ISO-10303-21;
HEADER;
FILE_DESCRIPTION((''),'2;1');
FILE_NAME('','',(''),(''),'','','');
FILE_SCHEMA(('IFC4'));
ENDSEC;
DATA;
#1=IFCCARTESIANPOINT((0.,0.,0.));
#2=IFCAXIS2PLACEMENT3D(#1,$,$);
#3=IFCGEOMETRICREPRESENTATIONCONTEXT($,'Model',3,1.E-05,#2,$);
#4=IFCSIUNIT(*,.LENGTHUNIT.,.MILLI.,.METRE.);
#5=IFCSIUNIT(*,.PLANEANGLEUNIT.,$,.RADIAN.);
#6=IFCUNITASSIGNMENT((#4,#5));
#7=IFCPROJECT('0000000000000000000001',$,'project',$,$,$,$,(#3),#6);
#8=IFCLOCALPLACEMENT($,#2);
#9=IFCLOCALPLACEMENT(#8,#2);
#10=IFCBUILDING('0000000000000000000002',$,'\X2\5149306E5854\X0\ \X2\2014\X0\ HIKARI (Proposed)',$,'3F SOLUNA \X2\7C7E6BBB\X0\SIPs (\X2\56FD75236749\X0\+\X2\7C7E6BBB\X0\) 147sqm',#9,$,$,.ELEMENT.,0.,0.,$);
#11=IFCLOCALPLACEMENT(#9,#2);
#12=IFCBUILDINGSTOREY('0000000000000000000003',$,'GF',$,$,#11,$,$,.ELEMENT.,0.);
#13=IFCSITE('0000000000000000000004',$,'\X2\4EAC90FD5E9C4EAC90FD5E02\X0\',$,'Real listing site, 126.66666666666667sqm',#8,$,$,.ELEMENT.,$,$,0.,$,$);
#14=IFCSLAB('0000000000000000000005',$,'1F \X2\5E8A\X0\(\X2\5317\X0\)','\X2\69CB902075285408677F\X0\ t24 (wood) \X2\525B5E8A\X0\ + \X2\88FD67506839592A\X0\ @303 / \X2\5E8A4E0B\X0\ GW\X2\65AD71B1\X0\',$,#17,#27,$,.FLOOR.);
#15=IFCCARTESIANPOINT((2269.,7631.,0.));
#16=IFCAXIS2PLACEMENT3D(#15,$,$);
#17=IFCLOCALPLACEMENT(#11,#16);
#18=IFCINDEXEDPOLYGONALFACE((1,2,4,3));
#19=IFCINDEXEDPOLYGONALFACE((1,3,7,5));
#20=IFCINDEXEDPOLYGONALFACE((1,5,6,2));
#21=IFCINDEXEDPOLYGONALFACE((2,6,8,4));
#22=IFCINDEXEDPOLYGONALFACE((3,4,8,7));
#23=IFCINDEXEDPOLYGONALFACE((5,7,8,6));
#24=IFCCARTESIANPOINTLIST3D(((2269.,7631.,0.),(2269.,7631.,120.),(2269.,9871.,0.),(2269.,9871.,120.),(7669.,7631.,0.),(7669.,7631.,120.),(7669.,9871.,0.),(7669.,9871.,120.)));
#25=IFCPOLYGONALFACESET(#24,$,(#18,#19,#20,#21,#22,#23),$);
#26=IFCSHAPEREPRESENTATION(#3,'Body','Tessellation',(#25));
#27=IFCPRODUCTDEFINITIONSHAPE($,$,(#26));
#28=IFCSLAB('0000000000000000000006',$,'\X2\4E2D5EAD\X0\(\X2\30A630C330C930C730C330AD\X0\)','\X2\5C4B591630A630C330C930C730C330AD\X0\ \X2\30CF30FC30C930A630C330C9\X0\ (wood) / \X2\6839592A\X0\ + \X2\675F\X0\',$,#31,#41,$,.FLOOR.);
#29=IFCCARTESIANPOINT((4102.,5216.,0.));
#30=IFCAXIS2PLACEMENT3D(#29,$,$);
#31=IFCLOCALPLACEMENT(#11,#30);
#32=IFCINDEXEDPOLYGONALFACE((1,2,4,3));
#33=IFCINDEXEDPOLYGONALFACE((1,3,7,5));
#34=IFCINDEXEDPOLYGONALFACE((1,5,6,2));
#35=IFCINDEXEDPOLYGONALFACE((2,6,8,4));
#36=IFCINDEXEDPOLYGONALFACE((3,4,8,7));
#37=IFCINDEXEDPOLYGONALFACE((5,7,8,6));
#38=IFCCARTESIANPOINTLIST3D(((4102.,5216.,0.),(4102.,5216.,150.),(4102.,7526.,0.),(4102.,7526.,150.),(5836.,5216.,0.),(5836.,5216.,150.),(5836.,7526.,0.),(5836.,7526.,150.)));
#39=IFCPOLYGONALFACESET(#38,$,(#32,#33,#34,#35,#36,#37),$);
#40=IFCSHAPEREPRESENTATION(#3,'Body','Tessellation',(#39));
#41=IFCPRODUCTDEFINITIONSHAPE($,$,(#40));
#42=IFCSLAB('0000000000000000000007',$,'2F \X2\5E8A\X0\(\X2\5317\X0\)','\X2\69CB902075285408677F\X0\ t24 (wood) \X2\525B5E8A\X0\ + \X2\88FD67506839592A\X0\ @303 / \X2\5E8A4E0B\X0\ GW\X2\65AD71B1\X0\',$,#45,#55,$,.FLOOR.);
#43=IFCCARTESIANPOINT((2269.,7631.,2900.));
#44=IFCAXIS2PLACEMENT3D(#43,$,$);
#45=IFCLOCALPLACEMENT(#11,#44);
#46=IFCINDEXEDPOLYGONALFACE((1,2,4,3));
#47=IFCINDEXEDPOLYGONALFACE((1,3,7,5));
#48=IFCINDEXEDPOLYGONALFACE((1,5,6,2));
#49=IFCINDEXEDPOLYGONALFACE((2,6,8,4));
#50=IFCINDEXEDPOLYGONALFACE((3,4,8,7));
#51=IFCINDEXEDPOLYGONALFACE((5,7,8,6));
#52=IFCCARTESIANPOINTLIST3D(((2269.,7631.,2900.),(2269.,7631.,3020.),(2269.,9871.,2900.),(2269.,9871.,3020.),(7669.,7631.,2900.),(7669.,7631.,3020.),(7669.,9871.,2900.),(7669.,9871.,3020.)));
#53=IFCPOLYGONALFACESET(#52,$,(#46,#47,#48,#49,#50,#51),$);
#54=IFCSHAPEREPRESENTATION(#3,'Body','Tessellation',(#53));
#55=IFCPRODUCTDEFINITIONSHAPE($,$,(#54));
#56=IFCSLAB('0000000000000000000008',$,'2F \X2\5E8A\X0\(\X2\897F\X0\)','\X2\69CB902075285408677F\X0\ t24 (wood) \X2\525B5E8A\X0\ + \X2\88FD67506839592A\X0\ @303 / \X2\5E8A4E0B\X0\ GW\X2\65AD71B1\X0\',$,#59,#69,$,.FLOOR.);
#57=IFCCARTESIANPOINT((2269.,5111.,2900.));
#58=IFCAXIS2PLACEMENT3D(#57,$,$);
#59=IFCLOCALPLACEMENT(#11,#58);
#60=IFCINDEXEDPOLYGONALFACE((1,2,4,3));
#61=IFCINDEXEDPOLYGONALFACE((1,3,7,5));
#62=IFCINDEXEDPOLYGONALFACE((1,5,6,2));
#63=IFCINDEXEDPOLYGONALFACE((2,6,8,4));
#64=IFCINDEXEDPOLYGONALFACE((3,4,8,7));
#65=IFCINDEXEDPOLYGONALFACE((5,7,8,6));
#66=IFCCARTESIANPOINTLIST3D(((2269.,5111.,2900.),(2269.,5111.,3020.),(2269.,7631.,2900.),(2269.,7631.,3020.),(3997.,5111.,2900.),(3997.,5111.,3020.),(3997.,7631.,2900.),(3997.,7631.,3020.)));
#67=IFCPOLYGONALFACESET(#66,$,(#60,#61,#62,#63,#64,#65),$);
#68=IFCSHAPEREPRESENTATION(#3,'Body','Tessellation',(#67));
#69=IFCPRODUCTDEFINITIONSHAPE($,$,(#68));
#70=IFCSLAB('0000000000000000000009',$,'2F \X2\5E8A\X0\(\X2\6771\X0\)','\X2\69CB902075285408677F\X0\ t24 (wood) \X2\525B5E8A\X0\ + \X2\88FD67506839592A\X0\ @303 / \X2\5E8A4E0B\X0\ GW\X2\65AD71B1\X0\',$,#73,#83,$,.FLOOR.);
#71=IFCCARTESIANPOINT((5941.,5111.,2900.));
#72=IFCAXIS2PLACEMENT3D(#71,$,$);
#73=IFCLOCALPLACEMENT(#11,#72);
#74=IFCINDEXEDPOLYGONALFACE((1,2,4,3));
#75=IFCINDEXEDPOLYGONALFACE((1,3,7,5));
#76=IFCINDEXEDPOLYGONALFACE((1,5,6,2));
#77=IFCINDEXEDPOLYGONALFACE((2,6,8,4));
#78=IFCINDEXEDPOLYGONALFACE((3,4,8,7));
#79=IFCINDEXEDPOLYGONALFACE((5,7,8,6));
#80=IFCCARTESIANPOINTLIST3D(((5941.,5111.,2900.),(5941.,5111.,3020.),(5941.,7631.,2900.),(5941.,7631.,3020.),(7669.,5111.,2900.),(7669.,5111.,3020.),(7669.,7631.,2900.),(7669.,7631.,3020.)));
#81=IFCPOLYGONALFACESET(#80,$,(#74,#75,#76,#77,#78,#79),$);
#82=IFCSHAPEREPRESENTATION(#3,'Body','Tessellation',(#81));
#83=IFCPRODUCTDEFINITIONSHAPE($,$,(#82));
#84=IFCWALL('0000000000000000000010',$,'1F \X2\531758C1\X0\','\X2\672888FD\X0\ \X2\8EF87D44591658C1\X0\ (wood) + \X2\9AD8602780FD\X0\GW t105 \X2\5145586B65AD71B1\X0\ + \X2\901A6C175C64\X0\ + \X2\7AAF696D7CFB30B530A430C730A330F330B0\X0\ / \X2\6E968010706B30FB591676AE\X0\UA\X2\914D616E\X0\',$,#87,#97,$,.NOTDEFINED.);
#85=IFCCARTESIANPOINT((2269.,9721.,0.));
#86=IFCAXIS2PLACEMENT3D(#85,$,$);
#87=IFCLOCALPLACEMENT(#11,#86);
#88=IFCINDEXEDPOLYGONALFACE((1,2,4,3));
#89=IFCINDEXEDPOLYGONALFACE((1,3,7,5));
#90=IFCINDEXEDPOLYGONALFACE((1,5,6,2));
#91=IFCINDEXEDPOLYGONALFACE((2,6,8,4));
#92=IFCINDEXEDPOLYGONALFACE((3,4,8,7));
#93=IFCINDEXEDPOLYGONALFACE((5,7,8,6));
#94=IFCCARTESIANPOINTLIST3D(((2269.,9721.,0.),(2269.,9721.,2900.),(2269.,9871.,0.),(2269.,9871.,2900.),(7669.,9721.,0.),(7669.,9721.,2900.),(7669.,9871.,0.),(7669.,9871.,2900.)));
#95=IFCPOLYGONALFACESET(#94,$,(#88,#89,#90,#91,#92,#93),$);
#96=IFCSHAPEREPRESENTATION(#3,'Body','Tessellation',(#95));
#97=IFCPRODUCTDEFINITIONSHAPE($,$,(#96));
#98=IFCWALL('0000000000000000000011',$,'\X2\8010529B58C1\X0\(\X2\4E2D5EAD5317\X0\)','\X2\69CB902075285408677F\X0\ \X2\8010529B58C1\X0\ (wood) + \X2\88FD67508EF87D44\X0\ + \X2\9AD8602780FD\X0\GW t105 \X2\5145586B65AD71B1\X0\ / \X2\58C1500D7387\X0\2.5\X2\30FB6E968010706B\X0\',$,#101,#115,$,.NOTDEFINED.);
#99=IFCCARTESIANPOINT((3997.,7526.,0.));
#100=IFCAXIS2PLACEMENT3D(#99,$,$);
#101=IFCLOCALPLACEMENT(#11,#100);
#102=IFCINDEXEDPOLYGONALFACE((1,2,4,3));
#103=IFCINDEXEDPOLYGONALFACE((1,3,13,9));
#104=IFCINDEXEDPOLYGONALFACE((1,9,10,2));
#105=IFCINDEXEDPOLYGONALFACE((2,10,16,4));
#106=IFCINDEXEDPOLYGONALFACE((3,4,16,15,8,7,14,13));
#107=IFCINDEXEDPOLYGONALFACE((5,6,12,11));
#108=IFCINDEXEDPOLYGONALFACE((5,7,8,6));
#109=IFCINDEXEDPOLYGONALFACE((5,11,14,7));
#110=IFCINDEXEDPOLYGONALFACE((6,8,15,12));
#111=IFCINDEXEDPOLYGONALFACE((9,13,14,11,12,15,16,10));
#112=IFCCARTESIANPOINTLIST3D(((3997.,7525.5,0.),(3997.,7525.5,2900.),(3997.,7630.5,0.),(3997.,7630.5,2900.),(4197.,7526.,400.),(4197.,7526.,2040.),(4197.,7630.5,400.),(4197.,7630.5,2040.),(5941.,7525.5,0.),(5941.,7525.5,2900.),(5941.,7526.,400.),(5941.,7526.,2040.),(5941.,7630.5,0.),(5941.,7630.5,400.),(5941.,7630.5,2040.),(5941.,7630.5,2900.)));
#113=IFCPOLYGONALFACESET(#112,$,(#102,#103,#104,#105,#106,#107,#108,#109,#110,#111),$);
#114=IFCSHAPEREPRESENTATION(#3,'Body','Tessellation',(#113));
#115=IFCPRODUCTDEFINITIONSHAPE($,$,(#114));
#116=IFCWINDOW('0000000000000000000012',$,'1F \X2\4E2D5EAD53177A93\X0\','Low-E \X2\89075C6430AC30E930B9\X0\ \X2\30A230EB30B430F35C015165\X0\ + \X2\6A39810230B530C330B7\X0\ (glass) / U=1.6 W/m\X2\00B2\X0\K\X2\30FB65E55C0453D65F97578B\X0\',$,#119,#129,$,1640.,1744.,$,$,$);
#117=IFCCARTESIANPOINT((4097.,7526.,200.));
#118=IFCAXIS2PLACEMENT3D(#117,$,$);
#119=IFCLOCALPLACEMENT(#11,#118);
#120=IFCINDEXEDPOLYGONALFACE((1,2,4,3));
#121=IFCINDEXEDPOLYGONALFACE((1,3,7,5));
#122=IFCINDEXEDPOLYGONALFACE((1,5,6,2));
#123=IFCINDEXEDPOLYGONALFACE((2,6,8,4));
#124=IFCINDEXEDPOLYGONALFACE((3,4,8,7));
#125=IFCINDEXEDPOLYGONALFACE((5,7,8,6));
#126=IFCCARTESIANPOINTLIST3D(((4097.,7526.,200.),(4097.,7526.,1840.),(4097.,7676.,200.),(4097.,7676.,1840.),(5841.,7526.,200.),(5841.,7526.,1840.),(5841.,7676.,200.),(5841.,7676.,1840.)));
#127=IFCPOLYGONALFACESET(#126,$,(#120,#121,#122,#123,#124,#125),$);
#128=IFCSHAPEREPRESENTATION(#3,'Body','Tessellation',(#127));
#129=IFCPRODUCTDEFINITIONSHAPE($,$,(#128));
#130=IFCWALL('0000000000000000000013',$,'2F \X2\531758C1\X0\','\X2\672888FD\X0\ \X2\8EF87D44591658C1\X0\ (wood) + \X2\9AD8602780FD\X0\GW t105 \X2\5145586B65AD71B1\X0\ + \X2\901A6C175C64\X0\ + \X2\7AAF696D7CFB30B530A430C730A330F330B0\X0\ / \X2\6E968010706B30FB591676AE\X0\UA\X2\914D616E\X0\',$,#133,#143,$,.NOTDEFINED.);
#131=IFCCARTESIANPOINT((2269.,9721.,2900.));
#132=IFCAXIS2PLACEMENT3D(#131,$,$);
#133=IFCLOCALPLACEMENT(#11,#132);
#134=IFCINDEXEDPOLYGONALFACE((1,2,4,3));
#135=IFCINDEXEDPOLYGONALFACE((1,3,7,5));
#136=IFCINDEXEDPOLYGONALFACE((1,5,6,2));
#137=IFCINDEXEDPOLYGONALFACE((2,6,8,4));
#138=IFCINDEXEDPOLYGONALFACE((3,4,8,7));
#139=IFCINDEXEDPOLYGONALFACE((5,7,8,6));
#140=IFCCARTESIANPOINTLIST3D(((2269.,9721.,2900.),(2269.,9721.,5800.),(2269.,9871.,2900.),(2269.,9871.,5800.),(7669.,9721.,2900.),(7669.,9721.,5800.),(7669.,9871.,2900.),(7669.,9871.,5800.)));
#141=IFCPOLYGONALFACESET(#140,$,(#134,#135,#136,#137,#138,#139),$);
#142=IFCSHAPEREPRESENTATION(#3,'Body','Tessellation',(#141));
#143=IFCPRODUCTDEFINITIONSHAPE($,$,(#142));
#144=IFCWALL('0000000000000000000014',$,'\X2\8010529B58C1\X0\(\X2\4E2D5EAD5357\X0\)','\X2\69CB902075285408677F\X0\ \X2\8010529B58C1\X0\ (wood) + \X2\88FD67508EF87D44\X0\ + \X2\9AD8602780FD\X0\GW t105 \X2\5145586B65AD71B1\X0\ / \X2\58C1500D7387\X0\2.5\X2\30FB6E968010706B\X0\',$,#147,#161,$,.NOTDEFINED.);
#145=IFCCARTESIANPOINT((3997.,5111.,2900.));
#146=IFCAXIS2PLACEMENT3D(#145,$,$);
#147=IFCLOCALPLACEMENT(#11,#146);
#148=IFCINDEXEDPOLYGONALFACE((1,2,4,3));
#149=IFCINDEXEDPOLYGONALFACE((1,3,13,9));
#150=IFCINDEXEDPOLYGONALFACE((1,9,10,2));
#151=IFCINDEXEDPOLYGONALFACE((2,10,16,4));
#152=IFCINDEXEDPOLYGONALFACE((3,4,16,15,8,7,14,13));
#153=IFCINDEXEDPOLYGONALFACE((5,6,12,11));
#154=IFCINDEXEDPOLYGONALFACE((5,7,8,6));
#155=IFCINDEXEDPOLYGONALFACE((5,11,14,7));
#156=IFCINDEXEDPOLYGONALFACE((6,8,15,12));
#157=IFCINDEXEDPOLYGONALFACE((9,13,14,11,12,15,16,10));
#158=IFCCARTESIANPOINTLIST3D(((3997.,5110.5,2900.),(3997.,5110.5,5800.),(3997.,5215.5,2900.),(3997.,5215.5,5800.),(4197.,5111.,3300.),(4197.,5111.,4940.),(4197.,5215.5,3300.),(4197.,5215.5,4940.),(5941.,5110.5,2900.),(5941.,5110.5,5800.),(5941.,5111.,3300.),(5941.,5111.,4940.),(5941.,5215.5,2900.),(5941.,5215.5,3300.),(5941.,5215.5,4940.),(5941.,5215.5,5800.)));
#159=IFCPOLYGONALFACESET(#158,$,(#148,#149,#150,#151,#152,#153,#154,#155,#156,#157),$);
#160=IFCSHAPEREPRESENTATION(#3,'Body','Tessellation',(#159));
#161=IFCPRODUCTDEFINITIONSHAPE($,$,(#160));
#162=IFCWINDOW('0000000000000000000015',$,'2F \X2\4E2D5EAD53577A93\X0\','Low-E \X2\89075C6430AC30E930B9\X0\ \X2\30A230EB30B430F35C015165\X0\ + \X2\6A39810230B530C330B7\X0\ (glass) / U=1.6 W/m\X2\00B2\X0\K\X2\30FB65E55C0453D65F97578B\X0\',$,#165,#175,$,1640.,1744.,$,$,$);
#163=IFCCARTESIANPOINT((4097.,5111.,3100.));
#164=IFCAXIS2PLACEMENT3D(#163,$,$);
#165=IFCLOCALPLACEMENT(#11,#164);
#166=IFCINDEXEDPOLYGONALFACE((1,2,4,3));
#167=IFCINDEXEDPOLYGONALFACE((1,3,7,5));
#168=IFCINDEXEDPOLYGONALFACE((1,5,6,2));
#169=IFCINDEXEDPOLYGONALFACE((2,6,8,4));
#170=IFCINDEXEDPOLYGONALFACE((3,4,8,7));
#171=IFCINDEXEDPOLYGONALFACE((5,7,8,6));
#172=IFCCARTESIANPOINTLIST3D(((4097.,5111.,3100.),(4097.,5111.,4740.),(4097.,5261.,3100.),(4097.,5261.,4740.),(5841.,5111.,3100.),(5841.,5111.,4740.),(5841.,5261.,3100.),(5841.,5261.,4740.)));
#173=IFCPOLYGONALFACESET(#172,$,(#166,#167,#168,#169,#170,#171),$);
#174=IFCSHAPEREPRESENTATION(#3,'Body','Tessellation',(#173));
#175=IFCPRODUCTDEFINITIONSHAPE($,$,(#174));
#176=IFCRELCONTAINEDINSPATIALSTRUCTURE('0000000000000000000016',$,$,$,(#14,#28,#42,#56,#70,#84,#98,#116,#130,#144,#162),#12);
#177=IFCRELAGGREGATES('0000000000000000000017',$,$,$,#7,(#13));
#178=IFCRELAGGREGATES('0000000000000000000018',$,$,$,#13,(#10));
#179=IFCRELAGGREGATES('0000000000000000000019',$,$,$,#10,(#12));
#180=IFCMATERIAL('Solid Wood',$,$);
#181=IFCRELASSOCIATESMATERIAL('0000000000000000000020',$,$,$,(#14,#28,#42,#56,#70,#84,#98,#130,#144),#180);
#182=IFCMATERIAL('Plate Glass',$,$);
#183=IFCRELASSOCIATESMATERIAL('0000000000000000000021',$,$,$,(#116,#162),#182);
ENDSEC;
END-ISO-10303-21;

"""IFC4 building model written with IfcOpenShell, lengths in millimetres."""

from ifc_helpers import new_model, si_unit, frame, frame_2d, origin, place, context, project, spatial, rectangle, extrude, material, element, fill, save


model = new_model("IFC4")

# Units and contexts
model_context = context("Model", 3, precision=1e-05, world=origin())
ifc_project = project(units=[si_unit("LENGTHUNIT", "METRE", prefix="MILLI"), si_unit("PLANEANGLEUNIT", "RADIAN")], contexts=[model_context])

# Site, building, storey
site_placement = place(None, origin())
site = spatial("IfcSite", under=ifc_project, at=site_placement, Name="京都府京都市", ObjectType="Real listing site, 126.66666666666667sqm", CompositionType="ELEMENT", RefElevation=0.0)
building_placement = place(site_placement, origin())
building = spatial("IfcBuilding", under=site, at=building_placement, Name="光の塔 — HIKARI (Proposed)", ObjectType="3F SOLUNA 籾殻SIPs (国産杉+籾殻) 147sqm", CompositionType="ELEMENT", ElevationOfRefHeight=0.0, ElevationOfTerrain=0.0)
storey_placement = place(building_placement, origin())
storey = spatial("IfcBuildingStorey", under=building, at=storey_placement, Name="GF", CompositionType="ELEMENT", Elevation=0.0)

# Slabs
ifc_material_1 = material(Name="Solid Wood")
slab_1_placement = place(storey_placement, frame((2269.0, 7631.0, 0.0)))
element("IfcSlab", 1, at=slab_1_placement, inside=storey, material=ifc_material_1, Name="1F 床(北)", Description="構造用合板 t24 (wood) 剛床 + 製材根太 @303 / 床下 GW断熱", PredefinedType="FLOOR", context=model_context, shape_type="SweptSolid", body=[
    extrude(rectangle(XDim=5400.0, YDim=2240.0, at=frame_2d((2700.0, 1120.0))), frame((2269.0, 7631.0, 0.0)), (0.0, 0.0, 1.0), 120.0),
])
slab_2_placement = place(storey_placement, frame((4102.0, 5216.0, 0.0)))
element("IfcSlab", 2, at=slab_2_placement, inside=storey, material=ifc_material_1, Name="中庭(ウッドデッキ)", Description="屋外ウッドデッキ ハードウッド (wood) / 根太 + 束", PredefinedType="FLOOR", context=model_context, shape_type="SweptSolid", body=[
    extrude(rectangle(XDim=1734.0, YDim=2310.0, at=frame_2d((867.0, 1155.0))), frame((4102.0, 5216.0, 0.0)), (0.0, 0.0, 1.0), 150.0),
])
slab_3_placement = place(storey_placement, frame((2269.0, 7631.0, 2900.0)))
element("IfcSlab", 3, at=slab_3_placement, inside=storey, material=ifc_material_1, Name="2F 床(北)", Description="構造用合板 t24 (wood) 剛床 + 製材根太 @303 / 床下 GW断熱", PredefinedType="FLOOR", context=model_context, shape_type="SweptSolid", body=[
    extrude(rectangle(XDim=5400.0, YDim=2240.0, at=frame_2d((2700.0, 1120.0))), frame((2269.0, 7631.0, 2900.0)), (0.0, 0.0, 1.0), 120.0),
])
slab_4_placement = place(storey_placement, frame((2269.0, 5111.0, 2900.0)))
element("IfcSlab", 4, at=slab_4_placement, inside=storey, material=ifc_material_1, Name="2F 床(西)", Description="構造用合板 t24 (wood) 剛床 + 製材根太 @303 / 床下 GW断熱", PredefinedType="FLOOR", context=model_context, shape_type="SweptSolid", body=[
    extrude(rectangle(XDim=1728.0, YDim=2520.0, at=frame_2d((864.0, 1260.0))), frame((2269.0, 5111.0, 2900.0)), (0.0, 0.0, 1.0), 120.0),
])
slab_5_placement = place(storey_placement, frame((5941.0, 5111.0, 2900.0)))
element("IfcSlab", 5, at=slab_5_placement, inside=storey, material=ifc_material_1, Name="2F 床(東)", Description="構造用合板 t24 (wood) 剛床 + 製材根太 @303 / 床下 GW断熱", PredefinedType="FLOOR", context=model_context, shape_type="SweptSolid", body=[
    extrude(rectangle(XDim=1728.0, YDim=2520.0, at=frame_2d((864.0, 1260.0))), frame((5941.0, 5111.0, 2900.0)), (0.0, 0.0, 1.0), 120.0),
])

# Wall
wall_1_placement = place(storey_placement, frame((2269.0, 9721.0, 0.0)))
element("IfcWall", 6, at=wall_1_placement, inside=storey, material=ifc_material_1, Name="1F 北壁", Description="木製 軸組外壁 (wood) + 高性能GW t105 充填断熱 + 通気層 + 窯業系サイディング / 準耐火・外皮UA配慮", PredefinedType="NOTDEFINED", context=model_context, shape_type="SweptSolid", body=[
    extrude(rectangle(XDim=5400.0, YDim=150.0, at=frame_2d((2700.0, 75.0))), frame((2269.0, 9721.0, 0.0)), (0.0, 0.0, 1.0), 2900.0),
])

# Wall, opening, window
wall_2_placement = place(storey_placement, frame((3997.0, 7526.0, 0.0)))
wall_2 = element("IfcWall", 7, at=wall_2_placement, inside=storey, material=ifc_material_1, Name="耐力壁(中庭北)", Description="構造用合板 耐力壁 (wood) + 製材軸組 + 高性能GW t105 充填断熱 / 壁倍率2.5・準耐火", PredefinedType="NOTDEFINED", context=model_context, shape_type="SweptSolid", body=[
    extrude(rectangle(XDim=1944.0, YDim=105.0, at=frame_2d((972.0, 52.0))), frame((3997.0, 7526.0, 0.0)), (0.0, 0.0, 1.0), 2900.0),
])
opening_1_placement = place(storey_placement, frame((4097.0, 7526.0, 200.0)))
opening_1 = element("IfcOpeningElement", 8, at=opening_1_placement, cuts=wall_2, PredefinedType="NOTDEFINED", context=model_context, shape_type="SweptSolid", body=[
    extrude(rectangle(XDim=1744.0, YDim=150.0, at=frame_2d((872.0, 75.0))), frame((4097.0, 7526.0, 200.0)), (0.0, 0.0, 1.0), 1640.0),
])
ifc_material_2 = material(Name="Plate Glass")
window_1_placement = place(storey_placement, frame((4097.0, 7526.0, 200.0)))
window_1 = element("IfcWindow", 9, at=window_1_placement, inside=storey, material=ifc_material_2, Name="1F 中庭北窓", Description="Low-E 複層ガラス アルゴン封入 + 樹脂サッシ (glass) / U=1.6 W/m²K・日射取得型", OverallHeight=1640.0, OverallWidth=1744.0, context=model_context, shape_type="SweptSolid", body=[
    extrude(rectangle(XDim=1744.0, YDim=150.0, at=frame_2d((872.0, 75.0))), frame((4097.0, 7526.0, 200.0)), (0.0, 0.0, 1.0), 1640.0),
])
fill(opening_1, window_1)

# Wall
wall_3_placement = place(storey_placement, frame((2269.0, 9721.0, 2900.0)))
element("IfcWall", 10, at=wall_3_placement, inside=storey, material=ifc_material_1, Name="2F 北壁", Description="木製 軸組外壁 (wood) + 高性能GW t105 充填断熱 + 通気層 + 窯業系サイディング / 準耐火・外皮UA配慮", PredefinedType="NOTDEFINED", context=model_context, shape_type="SweptSolid", body=[
    extrude(rectangle(XDim=5400.0, YDim=150.0, at=frame_2d((2700.0, 75.0))), frame((2269.0, 9721.0, 2900.0)), (0.0, 0.0, 1.0), 2900.0),
])

# Wall, opening, window
wall_4_placement = place(storey_placement, frame((3997.0, 5111.0, 2900.0)))
wall_4 = element("IfcWall", 11, at=wall_4_placement, inside=storey, material=ifc_material_1, Name="耐力壁(中庭南)", Description="構造用合板 耐力壁 (wood) + 製材軸組 + 高性能GW t105 充填断熱 / 壁倍率2.5・準耐火", PredefinedType="NOTDEFINED", context=model_context, shape_type="SweptSolid", body=[
    extrude(rectangle(XDim=1944.0, YDim=105.0, at=frame_2d((972.0, 52.0))), frame((3997.0, 5111.0, 2900.0)), (0.0, 0.0, 1.0), 2900.0),
])
opening_2_placement = place(storey_placement, frame((4097.0, 5111.0, 3100.0)))
opening_2 = element("IfcOpeningElement", 12, at=opening_2_placement, cuts=wall_4, PredefinedType="NOTDEFINED", context=model_context, shape_type="SweptSolid", body=[
    extrude(rectangle(XDim=1744.0, YDim=150.0, at=frame_2d((872.0, 75.0))), frame((4097.0, 5111.0, 3100.0)), (0.0, 0.0, 1.0), 1640.0),
])
window_2_placement = place(storey_placement, frame((4097.0, 5111.0, 3100.0)))
window_2 = element("IfcWindow", 13, at=window_2_placement, inside=storey, material=ifc_material_2, Name="2F 中庭南窓", Description="Low-E 複層ガラス アルゴン封入 + 樹脂サッシ (glass) / U=1.6 W/m²K・日射取得型", OverallHeight=1640.0, OverallWidth=1744.0, context=model_context, shape_type="SweptSolid", body=[
    extrude(rectangle(XDim=1744.0, YDim=150.0, at=frame_2d((872.0, 75.0))), frame((4097.0, 5111.0, 3100.0)), (0.0, 0.0, 1.0), 1640.0),
])
fill(opening_2, window_2)

save(model, "model.ifc")
